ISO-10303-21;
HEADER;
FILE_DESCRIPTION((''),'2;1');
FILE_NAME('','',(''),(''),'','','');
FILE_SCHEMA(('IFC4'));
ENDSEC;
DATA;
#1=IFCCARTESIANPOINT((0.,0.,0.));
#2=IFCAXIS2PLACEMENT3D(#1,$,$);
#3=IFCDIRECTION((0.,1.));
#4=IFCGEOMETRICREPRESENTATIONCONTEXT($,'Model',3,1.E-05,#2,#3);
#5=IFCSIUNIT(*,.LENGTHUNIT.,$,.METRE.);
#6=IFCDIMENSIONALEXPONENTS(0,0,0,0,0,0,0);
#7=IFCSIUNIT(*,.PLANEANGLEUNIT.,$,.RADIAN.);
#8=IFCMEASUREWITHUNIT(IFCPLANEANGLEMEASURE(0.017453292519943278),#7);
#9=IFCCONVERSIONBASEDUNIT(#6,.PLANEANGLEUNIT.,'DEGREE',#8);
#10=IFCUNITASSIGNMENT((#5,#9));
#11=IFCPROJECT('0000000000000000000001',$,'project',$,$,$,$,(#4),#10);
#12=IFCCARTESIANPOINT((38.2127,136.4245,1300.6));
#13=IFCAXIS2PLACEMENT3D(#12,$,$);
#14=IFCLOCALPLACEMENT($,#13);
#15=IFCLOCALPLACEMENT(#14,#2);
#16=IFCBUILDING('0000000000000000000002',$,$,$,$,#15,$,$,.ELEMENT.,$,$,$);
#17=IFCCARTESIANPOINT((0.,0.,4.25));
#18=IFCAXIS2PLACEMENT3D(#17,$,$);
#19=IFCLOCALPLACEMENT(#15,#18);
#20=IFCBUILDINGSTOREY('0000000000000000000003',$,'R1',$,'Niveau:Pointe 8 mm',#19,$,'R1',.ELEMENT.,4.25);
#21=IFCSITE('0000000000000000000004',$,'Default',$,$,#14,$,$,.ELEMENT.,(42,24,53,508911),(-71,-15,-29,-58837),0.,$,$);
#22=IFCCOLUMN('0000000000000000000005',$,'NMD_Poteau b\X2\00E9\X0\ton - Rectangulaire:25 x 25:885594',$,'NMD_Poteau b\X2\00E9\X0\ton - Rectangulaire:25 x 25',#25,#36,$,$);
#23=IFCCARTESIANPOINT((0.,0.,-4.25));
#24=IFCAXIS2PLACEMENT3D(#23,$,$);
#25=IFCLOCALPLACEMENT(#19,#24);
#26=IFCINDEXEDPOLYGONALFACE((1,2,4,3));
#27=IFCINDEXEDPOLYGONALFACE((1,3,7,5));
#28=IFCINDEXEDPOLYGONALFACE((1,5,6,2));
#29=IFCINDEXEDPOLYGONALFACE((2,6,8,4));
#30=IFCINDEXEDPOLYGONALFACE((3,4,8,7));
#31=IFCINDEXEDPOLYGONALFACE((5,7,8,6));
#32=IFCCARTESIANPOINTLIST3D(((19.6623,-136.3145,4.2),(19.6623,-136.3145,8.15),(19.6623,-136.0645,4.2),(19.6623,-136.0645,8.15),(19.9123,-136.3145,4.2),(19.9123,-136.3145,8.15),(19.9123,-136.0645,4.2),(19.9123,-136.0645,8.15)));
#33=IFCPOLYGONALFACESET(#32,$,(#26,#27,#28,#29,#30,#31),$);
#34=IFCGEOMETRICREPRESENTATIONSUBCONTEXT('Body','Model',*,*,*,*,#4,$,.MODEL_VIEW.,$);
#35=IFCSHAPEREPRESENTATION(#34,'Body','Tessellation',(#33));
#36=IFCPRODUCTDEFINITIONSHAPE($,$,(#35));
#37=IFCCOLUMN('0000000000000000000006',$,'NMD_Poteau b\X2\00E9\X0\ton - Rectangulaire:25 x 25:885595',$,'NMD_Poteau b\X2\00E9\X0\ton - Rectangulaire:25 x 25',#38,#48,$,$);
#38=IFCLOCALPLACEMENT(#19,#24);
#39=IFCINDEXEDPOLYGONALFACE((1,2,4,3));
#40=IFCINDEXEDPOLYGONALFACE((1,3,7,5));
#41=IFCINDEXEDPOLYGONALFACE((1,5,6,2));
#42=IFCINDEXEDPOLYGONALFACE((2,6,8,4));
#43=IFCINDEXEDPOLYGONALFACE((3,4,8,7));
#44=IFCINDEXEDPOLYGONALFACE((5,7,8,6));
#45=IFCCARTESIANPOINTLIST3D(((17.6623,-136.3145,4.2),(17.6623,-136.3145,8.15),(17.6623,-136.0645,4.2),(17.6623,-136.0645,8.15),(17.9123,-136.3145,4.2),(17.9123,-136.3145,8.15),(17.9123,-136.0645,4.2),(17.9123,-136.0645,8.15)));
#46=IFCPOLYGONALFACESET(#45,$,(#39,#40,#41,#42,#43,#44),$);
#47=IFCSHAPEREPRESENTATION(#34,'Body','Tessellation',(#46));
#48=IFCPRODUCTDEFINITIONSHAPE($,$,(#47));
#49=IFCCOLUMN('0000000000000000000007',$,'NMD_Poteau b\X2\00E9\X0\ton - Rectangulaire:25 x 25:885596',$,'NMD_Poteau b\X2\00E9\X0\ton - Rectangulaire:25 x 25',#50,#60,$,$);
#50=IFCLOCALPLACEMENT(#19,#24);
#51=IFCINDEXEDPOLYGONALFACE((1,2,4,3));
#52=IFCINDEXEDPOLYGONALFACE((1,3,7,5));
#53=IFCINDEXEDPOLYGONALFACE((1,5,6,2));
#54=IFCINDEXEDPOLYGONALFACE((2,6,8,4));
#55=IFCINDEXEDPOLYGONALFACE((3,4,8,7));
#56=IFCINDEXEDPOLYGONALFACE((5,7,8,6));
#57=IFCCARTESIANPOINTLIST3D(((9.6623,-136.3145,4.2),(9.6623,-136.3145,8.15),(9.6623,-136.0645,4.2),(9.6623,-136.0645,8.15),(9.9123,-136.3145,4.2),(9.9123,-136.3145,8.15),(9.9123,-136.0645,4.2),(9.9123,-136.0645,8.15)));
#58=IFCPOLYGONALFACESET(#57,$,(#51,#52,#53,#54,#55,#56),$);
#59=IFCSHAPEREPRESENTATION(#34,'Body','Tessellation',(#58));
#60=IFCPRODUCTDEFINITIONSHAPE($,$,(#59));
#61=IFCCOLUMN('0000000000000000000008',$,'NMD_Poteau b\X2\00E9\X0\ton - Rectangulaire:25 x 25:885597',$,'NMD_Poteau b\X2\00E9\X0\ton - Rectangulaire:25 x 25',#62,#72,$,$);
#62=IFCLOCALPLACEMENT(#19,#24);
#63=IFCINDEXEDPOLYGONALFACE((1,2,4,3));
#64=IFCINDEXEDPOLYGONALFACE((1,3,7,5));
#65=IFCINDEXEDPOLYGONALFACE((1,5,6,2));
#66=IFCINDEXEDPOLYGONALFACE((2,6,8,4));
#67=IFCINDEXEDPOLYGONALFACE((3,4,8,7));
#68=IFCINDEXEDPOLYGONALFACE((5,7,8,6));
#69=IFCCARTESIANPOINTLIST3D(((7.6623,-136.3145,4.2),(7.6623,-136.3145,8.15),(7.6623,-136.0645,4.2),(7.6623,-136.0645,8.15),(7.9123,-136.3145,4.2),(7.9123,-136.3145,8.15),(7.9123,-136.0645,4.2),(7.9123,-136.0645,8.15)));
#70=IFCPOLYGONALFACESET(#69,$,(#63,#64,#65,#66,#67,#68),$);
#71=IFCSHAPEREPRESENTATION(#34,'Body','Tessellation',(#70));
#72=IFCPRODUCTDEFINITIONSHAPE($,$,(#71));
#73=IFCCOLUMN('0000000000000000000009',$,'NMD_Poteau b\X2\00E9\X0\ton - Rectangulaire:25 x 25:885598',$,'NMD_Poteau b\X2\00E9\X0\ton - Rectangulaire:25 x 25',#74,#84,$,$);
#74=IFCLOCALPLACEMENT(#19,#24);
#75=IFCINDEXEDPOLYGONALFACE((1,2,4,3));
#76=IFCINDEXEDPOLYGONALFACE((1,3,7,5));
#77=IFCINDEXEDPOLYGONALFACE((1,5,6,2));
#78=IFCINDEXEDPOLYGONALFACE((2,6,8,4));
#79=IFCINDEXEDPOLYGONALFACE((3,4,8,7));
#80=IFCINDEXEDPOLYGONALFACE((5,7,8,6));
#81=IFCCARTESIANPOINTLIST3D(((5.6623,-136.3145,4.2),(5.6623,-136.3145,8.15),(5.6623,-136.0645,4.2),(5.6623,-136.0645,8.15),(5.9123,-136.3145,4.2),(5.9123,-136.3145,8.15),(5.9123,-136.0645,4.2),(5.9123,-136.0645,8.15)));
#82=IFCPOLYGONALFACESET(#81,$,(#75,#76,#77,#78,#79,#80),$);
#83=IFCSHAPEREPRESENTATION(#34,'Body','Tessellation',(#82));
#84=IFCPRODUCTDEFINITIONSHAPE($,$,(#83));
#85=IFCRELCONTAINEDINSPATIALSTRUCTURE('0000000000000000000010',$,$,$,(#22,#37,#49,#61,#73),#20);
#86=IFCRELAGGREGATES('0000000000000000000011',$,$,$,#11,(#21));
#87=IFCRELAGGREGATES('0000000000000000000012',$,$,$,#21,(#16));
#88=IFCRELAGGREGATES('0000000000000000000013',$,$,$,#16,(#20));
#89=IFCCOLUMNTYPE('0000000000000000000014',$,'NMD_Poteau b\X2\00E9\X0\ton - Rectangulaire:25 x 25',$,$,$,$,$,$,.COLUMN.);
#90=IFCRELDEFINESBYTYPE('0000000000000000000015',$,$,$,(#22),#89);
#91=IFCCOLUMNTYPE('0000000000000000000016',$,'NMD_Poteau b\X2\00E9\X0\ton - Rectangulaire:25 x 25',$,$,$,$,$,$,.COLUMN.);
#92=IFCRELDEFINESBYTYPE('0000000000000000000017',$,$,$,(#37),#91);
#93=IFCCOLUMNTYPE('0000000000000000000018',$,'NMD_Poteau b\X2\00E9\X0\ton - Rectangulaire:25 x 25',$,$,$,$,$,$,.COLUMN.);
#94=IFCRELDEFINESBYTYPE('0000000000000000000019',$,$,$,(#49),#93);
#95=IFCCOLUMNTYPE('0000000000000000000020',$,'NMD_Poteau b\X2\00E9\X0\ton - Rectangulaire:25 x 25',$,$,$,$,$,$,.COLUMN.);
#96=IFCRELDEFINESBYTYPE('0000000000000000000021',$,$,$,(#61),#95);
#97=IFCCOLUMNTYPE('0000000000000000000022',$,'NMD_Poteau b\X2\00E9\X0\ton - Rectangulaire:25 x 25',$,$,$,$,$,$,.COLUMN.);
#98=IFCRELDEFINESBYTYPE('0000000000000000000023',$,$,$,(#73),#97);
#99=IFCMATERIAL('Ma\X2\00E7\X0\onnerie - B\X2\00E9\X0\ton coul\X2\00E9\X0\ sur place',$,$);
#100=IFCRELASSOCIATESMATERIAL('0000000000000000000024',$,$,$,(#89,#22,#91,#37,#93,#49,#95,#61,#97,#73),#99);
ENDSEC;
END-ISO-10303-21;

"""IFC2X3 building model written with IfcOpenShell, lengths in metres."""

from ifc_helpers import new_model, entity, si_unit, converted_unit, direction, frame, frame_2d, origin, place, context, subcontext, project, spatial, rectangle, extrude, source, transform, mapped, material, type_object, type_shapes, element, save


model = new_model("IFC2X3")

# Units and contexts
model_context = context("Model", 3, precision=1e-05, world=origin(), true_north=direction((0.0, 1.0)))
body_context = subcontext(model_context, "Body", "Model", "MODEL_VIEW")
ifc_project = project(units=[si_unit("LENGTHUNIT", "METRE"), converted_unit("PLANEANGLEUNIT", "DEGREE", entity("IfcPlaneAngleMeasure", 0.017453292519943278), si_unit("PLANEANGLEUNIT", "RADIAN"), dimensions=[0, 0, 0, 0, 0, 0, 0])], contexts=[model_context])

# Site, building, storey
site_placement = place(None, frame((38.2127, 136.4245, 1300.6)))
site = spatial("IfcSite", under=ifc_project, at=site_placement, Name="Default", CompositionType="ELEMENT", RefLatitude=(42, 24, 53, 508911), RefLongitude=(-71, -15, -29, -58837), RefElevation=0.0)
building_placement = place(site_placement, origin())
building = spatial("IfcBuilding", under=site, at=building_placement, CompositionType="ELEMENT")
storey_placement = place(building_placement, frame((0.0, 0.0, 4.25)))
storey = spatial("IfcBuildingStorey", under=building, at=storey_placement, Name="R1", ObjectType="Niveau:Pointe 8 mm", LongName="R1", CompositionType="ELEMENT", Elevation=4.25)

# Columns
ifc_material = material(Name="Maçonnerie - Béton coulé sur place")
column_type_1 = type_object("IfcColumnType", Name="NMD_Poteau béton - Rectangulaire:25 x 25", PredefinedType="COLUMN", material=ifc_material)
shared_shape_1 = source(origin(), body_context, "Body", "SweptSolid", [
    extrude(rectangle(XDim=0.25, YDim=0.25, at=frame_2d((0.0, 0.0), x_axis=(1.0, 0.0))), frame((19.7873, -136.1895, 4.2), z_axis=(0.0, 0.0, 1.0), x_axis=(-1.0, 0.0, 0.0)), (0.0, 0.0, 1.0), 3.95),
])
type_shapes(column_type_1, [shared_shape_1])
column_1_placement = place(storey_placement, frame((0.0, 0.0, -4.25)))
element("IfcColumn", 1, at=column_1_placement, inside=storey, type_object=column_type_1, material=ifc_material, Name="NMD_Poteau béton - Rectangulaire:25 x 25:885594", ObjectType="NMD_Poteau béton - Rectangulaire:25 x 25", context=body_context, shape_type="MappedRepresentation", body=[
    mapped(shared_shape_1, transform((0.0, 0.0, 0.0), scale=1.0)),
])
column_type_2 = type_object("IfcColumnType", Name="NMD_Poteau béton - Rectangulaire:25 x 25", PredefinedType="COLUMN", material=ifc_material)
shared_shape_2 = source(origin(), body_context, "Body", "SweptSolid", [
    extrude(rectangle(XDim=0.25, YDim=0.25, at=frame_2d((0.0, 0.0), x_axis=(1.0, 0.0))), frame((17.7873, -136.1895, 4.2), z_axis=(0.0, 0.0, 1.0), x_axis=(-1.0, 0.0, 0.0)), (0.0, 0.0, 1.0), 3.95),
])
type_shapes(column_type_2, [shared_shape_2])
column_2_placement = place(storey_placement, frame((0.0, 0.0, -4.25)))
element("IfcColumn", 2, at=column_2_placement, inside=storey, type_object=column_type_2, material=ifc_material, Name="NMD_Poteau béton - Rectangulaire:25 x 25:885595", ObjectType="NMD_Poteau béton - Rectangulaire:25 x 25", context=body_context, shape_type="MappedRepresentation", body=[
    mapped(shared_shape_2, transform((0.0, 0.0, 0.0), scale=1.0)),
])
column_type_3 = type_object("IfcColumnType", Name="NMD_Poteau béton - Rectangulaire:25 x 25", PredefinedType="COLUMN", material=ifc_material)
shared_shape_3 = source(origin(), body_context, "Body", "SweptSolid", [
    extrude(rectangle(XDim=0.25, YDim=0.25, at=frame_2d((0.0, 0.0), x_axis=(1.0, 0.0))), frame((9.7873, -136.1895, 4.2), z_axis=(0.0, 0.0, 1.0), x_axis=(-1.0, 0.0, 0.0)), (0.0, 0.0, 1.0), 3.95),
])
type_shapes(column_type_3, [shared_shape_3])
column_3_placement = place(storey_placement, frame((0.0, 0.0, -4.25)))
element("IfcColumn", 3, at=column_3_placement, inside=storey, type_object=column_type_3, material=ifc_material, Name="NMD_Poteau béton - Rectangulaire:25 x 25:885596", ObjectType="NMD_Poteau béton - Rectangulaire:25 x 25", context=body_context, shape_type="MappedRepresentation", body=[
    mapped(shared_shape_3, transform((0.0, 0.0, 0.0), scale=1.0)),
])
column_type_4 = type_object("IfcColumnType", Name="NMD_Poteau béton - Rectangulaire:25 x 25", PredefinedType="COLUMN", material=ifc_material)
shared_shape_4 = source(origin(), body_context, "Body", "SweptSolid", [
    extrude(rectangle(XDim=0.25, YDim=0.25, at=frame_2d((0.0, 0.0), x_axis=(1.0, 0.0))), frame((7.7873, -136.1895, 4.2), z_axis=(0.0, 0.0, 1.0), x_axis=(-1.0, 0.0, 0.0)), (0.0, 0.0, 1.0), 3.95),
])
type_shapes(column_type_4, [shared_shape_4])
column_4_placement = place(storey_placement, frame((0.0, 0.0, -4.25)))
element("IfcColumn", 4, at=column_4_placement, inside=storey, type_object=column_type_4, material=ifc_material, Name="NMD_Poteau béton - Rectangulaire:25 x 25:885597", ObjectType="NMD_Poteau béton - Rectangulaire:25 x 25", context=body_context, shape_type="MappedRepresentation", body=[
    mapped(shared_shape_4, transform((0.0, 0.0, 0.0), scale=1.0)),
])
column_type_5 = type_object("IfcColumnType", Name="NMD_Poteau béton - Rectangulaire:25 x 25", PredefinedType="COLUMN", material=ifc_material)
shared_shape_5 = source(origin(), body_context, "Body", "SweptSolid", [
    extrude(rectangle(XDim=0.25, YDim=0.25, at=frame_2d((0.0, 0.0), x_axis=(1.0, 0.0))), frame((5.7873, -136.1895, 4.2), z_axis=(0.0, 0.0, 1.0), x_axis=(-1.0, 0.0, 0.0)), (0.0, 0.0, 1.0), 3.95),
])
type_shapes(column_type_5, [shared_shape_5])
column_5_placement = place(storey_placement, frame((0.0, 0.0, -4.25)))
element("IfcColumn", 5, at=column_5_placement, inside=storey, type_object=column_type_5, material=ifc_material, Name="NMD_Poteau béton - Rectangulaire:25 x 25:885598", ObjectType="NMD_Poteau béton - Rectangulaire:25 x 25", context=body_context, shape_type="MappedRepresentation", body=[
    mapped(shared_shape_5, transform((0.0, 0.0, 0.0), scale=1.0)),
])

save(model, "model.ifc")
